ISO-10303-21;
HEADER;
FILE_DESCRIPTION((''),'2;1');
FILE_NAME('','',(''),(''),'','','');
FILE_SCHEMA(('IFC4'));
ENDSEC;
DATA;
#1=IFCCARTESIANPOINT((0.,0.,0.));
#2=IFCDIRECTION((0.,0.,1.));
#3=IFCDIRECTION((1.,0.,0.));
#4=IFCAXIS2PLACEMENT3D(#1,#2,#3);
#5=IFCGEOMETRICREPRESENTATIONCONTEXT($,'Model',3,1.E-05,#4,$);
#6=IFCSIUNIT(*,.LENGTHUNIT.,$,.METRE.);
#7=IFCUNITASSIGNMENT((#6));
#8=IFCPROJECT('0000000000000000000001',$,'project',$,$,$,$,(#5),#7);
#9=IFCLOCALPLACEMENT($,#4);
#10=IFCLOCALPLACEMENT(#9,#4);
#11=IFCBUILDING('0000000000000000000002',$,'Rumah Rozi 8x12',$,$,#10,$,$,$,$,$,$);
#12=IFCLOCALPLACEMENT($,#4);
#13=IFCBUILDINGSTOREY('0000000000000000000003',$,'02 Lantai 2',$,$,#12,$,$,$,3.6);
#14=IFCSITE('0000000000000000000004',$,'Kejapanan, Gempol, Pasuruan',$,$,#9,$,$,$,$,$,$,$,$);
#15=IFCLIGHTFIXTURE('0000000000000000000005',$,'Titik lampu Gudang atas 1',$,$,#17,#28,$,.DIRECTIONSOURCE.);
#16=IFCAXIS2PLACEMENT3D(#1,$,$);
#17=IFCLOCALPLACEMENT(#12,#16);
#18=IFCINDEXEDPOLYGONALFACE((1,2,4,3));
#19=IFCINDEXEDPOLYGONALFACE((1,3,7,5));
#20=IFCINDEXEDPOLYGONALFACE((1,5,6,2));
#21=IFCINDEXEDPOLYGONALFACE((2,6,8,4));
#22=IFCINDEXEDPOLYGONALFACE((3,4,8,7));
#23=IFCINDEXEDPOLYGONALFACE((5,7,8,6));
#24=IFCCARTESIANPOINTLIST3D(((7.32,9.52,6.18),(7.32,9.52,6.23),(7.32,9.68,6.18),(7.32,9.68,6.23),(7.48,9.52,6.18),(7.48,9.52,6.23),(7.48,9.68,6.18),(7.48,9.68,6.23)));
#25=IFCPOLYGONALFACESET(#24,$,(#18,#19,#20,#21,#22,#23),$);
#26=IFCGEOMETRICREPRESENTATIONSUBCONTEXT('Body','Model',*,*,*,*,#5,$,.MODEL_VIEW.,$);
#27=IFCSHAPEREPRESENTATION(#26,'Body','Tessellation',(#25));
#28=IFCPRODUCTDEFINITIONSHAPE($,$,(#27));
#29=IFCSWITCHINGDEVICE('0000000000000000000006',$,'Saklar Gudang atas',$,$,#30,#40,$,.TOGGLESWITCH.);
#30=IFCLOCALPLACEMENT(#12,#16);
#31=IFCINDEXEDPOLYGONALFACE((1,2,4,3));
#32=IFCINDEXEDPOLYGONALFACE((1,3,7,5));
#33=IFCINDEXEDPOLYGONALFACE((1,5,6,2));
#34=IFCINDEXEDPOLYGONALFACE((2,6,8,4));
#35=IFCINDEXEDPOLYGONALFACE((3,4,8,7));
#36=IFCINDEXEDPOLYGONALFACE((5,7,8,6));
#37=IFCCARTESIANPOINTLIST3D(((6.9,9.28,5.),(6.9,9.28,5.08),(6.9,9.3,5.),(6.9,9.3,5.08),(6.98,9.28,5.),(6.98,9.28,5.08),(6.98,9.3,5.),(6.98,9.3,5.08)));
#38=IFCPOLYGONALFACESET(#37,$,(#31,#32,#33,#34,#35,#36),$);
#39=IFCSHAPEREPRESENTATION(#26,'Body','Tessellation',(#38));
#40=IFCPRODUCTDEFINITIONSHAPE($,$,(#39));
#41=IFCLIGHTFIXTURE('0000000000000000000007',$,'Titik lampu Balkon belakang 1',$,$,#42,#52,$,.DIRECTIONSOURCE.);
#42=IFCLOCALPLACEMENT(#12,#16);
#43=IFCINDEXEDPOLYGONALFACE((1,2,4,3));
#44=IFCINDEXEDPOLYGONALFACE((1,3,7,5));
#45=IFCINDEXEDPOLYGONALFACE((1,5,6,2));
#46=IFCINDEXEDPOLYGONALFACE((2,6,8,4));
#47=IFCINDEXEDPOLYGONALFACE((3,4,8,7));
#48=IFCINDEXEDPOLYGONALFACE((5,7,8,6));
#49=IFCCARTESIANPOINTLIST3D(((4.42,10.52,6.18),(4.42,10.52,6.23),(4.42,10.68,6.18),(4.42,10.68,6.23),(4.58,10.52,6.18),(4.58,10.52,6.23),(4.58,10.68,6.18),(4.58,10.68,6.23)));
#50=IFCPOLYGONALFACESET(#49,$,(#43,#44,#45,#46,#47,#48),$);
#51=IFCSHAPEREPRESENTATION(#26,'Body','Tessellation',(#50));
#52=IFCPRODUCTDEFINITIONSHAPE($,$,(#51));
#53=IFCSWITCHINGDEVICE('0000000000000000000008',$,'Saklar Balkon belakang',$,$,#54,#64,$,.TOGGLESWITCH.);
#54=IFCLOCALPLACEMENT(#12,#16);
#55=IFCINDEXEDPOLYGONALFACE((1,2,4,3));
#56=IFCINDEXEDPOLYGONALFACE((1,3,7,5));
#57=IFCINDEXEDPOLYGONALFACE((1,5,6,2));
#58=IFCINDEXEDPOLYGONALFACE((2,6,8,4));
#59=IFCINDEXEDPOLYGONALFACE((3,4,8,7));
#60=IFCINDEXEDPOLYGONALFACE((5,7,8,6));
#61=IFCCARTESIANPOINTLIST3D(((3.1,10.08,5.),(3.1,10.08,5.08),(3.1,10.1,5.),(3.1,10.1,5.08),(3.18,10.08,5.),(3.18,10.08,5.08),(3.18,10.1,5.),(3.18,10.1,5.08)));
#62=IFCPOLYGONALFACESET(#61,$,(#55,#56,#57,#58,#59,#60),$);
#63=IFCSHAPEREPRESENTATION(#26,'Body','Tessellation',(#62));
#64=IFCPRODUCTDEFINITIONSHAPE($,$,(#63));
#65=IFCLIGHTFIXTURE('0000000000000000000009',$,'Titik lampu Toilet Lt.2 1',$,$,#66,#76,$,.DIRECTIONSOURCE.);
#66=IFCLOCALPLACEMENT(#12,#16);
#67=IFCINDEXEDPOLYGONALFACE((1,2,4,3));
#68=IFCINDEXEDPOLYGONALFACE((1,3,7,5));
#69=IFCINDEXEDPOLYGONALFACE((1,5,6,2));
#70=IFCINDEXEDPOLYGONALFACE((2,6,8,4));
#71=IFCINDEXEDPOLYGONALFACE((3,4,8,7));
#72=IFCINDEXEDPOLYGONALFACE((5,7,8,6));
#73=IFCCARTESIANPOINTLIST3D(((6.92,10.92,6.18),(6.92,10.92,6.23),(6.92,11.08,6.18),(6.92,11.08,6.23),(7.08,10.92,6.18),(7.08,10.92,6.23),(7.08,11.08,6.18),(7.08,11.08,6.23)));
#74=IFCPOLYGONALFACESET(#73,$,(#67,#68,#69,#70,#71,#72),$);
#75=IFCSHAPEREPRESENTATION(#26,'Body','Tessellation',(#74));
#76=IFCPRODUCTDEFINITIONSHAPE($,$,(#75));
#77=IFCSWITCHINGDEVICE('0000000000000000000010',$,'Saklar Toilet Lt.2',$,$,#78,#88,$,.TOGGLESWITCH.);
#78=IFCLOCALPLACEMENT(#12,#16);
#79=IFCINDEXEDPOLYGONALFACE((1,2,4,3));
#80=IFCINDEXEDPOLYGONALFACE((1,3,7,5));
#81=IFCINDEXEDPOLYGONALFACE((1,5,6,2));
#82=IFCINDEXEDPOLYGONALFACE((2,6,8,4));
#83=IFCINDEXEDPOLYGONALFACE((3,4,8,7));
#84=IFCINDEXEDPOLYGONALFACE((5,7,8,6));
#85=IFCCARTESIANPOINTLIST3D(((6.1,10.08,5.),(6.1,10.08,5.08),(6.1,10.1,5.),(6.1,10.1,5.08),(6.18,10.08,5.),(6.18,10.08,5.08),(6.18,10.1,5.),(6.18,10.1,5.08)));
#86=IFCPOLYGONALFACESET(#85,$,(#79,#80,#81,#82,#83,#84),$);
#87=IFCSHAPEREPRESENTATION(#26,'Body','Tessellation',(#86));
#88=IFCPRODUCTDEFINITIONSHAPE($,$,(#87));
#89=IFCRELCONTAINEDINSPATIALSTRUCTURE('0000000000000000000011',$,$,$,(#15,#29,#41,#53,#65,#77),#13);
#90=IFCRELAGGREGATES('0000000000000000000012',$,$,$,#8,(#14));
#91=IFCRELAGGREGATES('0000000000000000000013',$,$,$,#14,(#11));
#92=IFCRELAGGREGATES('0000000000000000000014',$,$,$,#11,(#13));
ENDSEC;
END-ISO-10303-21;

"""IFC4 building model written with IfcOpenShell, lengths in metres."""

from ifc_helpers import new_model, si_unit, frame, origin_with_axes, place, context, subcontext, project, spatial, line, indexed_curve, outline, extrude, element, save


model = new_model("IFC4")

# Units and contexts
model_context = context("Model", 3, precision=1e-05, world=origin_with_axes())
body_context = subcontext(model_context, "Body", "Model", "MODEL_VIEW")
ifc_project = project(units=[si_unit("LENGTHUNIT", "METRE")], contexts=[model_context])

# Site, building, storey
site_placement = place(None, origin_with_axes())
site = spatial("IfcSite", under=ifc_project, at=site_placement, Name="Kejapanan, Gempol, Pasuruan")
building_placement = place(site_placement, origin_with_axes())
building = spatial("IfcBuilding", under=site, at=building_placement, Name="Rumah Rozi 8x12")
storey_placement = place(None, origin_with_axes())
storey = spatial("IfcBuildingStorey", under=building, at=storey_placement, Name="02 Lantai 2", Elevation=3.6)

# Light fixture
light_fixture_1_placement = place(storey_placement, origin_with_axes())
element("IfcLightFixture", 1, at=light_fixture_1_placement, inside=storey, Name="Titik lampu Gudang atas 1", PredefinedType="DIRECTIONSOURCE", context=body_context, shape_type="SweptSolid", body=[
    extrude(outline(indexed_curve([(7.32, 9.52), (7.48, 9.52), (7.48, 9.68), (7.32, 9.68)], segments=[line(1, 2, 3, 4, 1)])), frame((0.0, 0.0, 6.18), z_axis=(0.0, 0.0, 1.0), x_axis=(1.0, 0.0, 0.0)), (0.0, 0.0, 1.0), 0.05),
])

# Switching device
switching_device_1_placement = place(storey_placement, origin_with_axes())
element("IfcSwitchingDevice", 2, at=switching_device_1_placement, inside=storey, Name="Saklar Gudang atas", PredefinedType="TOGGLESWITCH", context=body_context, shape_type="SweptSolid", body=[
    extrude(outline(indexed_curve([(6.9, 9.28), (6.98, 9.28), (6.98, 9.3), (6.9, 9.3)], segments=[line(1, 2, 3, 4, 1)])), frame((0.0, 0.0, 5.0), z_axis=(0.0, 0.0, 1.0), x_axis=(1.0, 0.0, 0.0)), (0.0, 0.0, 1.0), 0.08),
])

# Light fixture
light_fixture_2_placement = place(storey_placement, origin_with_axes())
element("IfcLightFixture", 3, at=light_fixture_2_placement, inside=storey, Name="Titik lampu Balkon belakang 1", PredefinedType="DIRECTIONSOURCE", context=body_context, shape_type="SweptSolid", body=[
    extrude(outline(indexed_curve([(4.42, 10.52), (4.58, 10.52), (4.58, 10.68), (4.42, 10.68)], segments=[line(1, 2, 3, 4, 1)])), frame((0.0, 0.0, 6.18), z_axis=(0.0, 0.0, 1.0), x_axis=(1.0, 0.0, 0.0)), (0.0, 0.0, 1.0), 0.05),
])

# Switching device
switching_device_2_placement = place(storey_placement, origin_with_axes())
element("IfcSwitchingDevice", 4, at=switching_device_2_placement, inside=storey, Name="Saklar Balkon belakang", PredefinedType="TOGGLESWITCH", context=body_context, shape_type="SweptSolid", body=[
    extrude(outline(indexed_curve([(3.1, 10.08), (3.18, 10.08), (3.18, 10.1), (3.1, 10.1)], segments=[line(1, 2, 3, 4, 1)])), frame((0.0, 0.0, 5.0), z_axis=(0.0, 0.0, 1.0), x_axis=(1.0, 0.0, 0.0)), (0.0, 0.0, 1.0), 0.08),
])

# Light fixture
light_fixture_3_placement = place(storey_placement, origin_with_axes())
element("IfcLightFixture", 5, at=light_fixture_3_placement, inside=storey, Name="Titik lampu Toilet Lt.2 1", PredefinedType="DIRECTIONSOURCE", context=body_context, shape_type="SweptSolid", body=[
    extrude(outline(indexed_curve([(6.92, 10.92), (7.08, 10.92), (7.08, 11.08), (6.92, 11.08)], segments=[line(1, 2, 3, 4, 1)])), frame((0.0, 0.0, 6.18), z_axis=(0.0, 0.0, 1.0), x_axis=(1.0, 0.0, 0.0)), (0.0, 0.0, 1.0), 0.05),
])

# Switching device
switching_device_3_placement = place(storey_placement, origin_with_axes())
element("IfcSwitchingDevice", 6, at=switching_device_3_placement, inside=storey, Name="Saklar Toilet Lt.2", PredefinedType="TOGGLESWITCH", context=body_context, shape_type="SweptSolid", body=[
    extrude(outline(indexed_curve([(6.1, 10.08), (6.18, 10.08), (6.18, 10.1), (6.1, 10.1)], segments=[line(1, 2, 3, 4, 1)])), frame((0.0, 0.0, 5.0), z_axis=(0.0, 0.0, 1.0), x_axis=(1.0, 0.0, 0.0)), (0.0, 0.0, 1.0), 0.08),
])

save(model, "model.ifc")
